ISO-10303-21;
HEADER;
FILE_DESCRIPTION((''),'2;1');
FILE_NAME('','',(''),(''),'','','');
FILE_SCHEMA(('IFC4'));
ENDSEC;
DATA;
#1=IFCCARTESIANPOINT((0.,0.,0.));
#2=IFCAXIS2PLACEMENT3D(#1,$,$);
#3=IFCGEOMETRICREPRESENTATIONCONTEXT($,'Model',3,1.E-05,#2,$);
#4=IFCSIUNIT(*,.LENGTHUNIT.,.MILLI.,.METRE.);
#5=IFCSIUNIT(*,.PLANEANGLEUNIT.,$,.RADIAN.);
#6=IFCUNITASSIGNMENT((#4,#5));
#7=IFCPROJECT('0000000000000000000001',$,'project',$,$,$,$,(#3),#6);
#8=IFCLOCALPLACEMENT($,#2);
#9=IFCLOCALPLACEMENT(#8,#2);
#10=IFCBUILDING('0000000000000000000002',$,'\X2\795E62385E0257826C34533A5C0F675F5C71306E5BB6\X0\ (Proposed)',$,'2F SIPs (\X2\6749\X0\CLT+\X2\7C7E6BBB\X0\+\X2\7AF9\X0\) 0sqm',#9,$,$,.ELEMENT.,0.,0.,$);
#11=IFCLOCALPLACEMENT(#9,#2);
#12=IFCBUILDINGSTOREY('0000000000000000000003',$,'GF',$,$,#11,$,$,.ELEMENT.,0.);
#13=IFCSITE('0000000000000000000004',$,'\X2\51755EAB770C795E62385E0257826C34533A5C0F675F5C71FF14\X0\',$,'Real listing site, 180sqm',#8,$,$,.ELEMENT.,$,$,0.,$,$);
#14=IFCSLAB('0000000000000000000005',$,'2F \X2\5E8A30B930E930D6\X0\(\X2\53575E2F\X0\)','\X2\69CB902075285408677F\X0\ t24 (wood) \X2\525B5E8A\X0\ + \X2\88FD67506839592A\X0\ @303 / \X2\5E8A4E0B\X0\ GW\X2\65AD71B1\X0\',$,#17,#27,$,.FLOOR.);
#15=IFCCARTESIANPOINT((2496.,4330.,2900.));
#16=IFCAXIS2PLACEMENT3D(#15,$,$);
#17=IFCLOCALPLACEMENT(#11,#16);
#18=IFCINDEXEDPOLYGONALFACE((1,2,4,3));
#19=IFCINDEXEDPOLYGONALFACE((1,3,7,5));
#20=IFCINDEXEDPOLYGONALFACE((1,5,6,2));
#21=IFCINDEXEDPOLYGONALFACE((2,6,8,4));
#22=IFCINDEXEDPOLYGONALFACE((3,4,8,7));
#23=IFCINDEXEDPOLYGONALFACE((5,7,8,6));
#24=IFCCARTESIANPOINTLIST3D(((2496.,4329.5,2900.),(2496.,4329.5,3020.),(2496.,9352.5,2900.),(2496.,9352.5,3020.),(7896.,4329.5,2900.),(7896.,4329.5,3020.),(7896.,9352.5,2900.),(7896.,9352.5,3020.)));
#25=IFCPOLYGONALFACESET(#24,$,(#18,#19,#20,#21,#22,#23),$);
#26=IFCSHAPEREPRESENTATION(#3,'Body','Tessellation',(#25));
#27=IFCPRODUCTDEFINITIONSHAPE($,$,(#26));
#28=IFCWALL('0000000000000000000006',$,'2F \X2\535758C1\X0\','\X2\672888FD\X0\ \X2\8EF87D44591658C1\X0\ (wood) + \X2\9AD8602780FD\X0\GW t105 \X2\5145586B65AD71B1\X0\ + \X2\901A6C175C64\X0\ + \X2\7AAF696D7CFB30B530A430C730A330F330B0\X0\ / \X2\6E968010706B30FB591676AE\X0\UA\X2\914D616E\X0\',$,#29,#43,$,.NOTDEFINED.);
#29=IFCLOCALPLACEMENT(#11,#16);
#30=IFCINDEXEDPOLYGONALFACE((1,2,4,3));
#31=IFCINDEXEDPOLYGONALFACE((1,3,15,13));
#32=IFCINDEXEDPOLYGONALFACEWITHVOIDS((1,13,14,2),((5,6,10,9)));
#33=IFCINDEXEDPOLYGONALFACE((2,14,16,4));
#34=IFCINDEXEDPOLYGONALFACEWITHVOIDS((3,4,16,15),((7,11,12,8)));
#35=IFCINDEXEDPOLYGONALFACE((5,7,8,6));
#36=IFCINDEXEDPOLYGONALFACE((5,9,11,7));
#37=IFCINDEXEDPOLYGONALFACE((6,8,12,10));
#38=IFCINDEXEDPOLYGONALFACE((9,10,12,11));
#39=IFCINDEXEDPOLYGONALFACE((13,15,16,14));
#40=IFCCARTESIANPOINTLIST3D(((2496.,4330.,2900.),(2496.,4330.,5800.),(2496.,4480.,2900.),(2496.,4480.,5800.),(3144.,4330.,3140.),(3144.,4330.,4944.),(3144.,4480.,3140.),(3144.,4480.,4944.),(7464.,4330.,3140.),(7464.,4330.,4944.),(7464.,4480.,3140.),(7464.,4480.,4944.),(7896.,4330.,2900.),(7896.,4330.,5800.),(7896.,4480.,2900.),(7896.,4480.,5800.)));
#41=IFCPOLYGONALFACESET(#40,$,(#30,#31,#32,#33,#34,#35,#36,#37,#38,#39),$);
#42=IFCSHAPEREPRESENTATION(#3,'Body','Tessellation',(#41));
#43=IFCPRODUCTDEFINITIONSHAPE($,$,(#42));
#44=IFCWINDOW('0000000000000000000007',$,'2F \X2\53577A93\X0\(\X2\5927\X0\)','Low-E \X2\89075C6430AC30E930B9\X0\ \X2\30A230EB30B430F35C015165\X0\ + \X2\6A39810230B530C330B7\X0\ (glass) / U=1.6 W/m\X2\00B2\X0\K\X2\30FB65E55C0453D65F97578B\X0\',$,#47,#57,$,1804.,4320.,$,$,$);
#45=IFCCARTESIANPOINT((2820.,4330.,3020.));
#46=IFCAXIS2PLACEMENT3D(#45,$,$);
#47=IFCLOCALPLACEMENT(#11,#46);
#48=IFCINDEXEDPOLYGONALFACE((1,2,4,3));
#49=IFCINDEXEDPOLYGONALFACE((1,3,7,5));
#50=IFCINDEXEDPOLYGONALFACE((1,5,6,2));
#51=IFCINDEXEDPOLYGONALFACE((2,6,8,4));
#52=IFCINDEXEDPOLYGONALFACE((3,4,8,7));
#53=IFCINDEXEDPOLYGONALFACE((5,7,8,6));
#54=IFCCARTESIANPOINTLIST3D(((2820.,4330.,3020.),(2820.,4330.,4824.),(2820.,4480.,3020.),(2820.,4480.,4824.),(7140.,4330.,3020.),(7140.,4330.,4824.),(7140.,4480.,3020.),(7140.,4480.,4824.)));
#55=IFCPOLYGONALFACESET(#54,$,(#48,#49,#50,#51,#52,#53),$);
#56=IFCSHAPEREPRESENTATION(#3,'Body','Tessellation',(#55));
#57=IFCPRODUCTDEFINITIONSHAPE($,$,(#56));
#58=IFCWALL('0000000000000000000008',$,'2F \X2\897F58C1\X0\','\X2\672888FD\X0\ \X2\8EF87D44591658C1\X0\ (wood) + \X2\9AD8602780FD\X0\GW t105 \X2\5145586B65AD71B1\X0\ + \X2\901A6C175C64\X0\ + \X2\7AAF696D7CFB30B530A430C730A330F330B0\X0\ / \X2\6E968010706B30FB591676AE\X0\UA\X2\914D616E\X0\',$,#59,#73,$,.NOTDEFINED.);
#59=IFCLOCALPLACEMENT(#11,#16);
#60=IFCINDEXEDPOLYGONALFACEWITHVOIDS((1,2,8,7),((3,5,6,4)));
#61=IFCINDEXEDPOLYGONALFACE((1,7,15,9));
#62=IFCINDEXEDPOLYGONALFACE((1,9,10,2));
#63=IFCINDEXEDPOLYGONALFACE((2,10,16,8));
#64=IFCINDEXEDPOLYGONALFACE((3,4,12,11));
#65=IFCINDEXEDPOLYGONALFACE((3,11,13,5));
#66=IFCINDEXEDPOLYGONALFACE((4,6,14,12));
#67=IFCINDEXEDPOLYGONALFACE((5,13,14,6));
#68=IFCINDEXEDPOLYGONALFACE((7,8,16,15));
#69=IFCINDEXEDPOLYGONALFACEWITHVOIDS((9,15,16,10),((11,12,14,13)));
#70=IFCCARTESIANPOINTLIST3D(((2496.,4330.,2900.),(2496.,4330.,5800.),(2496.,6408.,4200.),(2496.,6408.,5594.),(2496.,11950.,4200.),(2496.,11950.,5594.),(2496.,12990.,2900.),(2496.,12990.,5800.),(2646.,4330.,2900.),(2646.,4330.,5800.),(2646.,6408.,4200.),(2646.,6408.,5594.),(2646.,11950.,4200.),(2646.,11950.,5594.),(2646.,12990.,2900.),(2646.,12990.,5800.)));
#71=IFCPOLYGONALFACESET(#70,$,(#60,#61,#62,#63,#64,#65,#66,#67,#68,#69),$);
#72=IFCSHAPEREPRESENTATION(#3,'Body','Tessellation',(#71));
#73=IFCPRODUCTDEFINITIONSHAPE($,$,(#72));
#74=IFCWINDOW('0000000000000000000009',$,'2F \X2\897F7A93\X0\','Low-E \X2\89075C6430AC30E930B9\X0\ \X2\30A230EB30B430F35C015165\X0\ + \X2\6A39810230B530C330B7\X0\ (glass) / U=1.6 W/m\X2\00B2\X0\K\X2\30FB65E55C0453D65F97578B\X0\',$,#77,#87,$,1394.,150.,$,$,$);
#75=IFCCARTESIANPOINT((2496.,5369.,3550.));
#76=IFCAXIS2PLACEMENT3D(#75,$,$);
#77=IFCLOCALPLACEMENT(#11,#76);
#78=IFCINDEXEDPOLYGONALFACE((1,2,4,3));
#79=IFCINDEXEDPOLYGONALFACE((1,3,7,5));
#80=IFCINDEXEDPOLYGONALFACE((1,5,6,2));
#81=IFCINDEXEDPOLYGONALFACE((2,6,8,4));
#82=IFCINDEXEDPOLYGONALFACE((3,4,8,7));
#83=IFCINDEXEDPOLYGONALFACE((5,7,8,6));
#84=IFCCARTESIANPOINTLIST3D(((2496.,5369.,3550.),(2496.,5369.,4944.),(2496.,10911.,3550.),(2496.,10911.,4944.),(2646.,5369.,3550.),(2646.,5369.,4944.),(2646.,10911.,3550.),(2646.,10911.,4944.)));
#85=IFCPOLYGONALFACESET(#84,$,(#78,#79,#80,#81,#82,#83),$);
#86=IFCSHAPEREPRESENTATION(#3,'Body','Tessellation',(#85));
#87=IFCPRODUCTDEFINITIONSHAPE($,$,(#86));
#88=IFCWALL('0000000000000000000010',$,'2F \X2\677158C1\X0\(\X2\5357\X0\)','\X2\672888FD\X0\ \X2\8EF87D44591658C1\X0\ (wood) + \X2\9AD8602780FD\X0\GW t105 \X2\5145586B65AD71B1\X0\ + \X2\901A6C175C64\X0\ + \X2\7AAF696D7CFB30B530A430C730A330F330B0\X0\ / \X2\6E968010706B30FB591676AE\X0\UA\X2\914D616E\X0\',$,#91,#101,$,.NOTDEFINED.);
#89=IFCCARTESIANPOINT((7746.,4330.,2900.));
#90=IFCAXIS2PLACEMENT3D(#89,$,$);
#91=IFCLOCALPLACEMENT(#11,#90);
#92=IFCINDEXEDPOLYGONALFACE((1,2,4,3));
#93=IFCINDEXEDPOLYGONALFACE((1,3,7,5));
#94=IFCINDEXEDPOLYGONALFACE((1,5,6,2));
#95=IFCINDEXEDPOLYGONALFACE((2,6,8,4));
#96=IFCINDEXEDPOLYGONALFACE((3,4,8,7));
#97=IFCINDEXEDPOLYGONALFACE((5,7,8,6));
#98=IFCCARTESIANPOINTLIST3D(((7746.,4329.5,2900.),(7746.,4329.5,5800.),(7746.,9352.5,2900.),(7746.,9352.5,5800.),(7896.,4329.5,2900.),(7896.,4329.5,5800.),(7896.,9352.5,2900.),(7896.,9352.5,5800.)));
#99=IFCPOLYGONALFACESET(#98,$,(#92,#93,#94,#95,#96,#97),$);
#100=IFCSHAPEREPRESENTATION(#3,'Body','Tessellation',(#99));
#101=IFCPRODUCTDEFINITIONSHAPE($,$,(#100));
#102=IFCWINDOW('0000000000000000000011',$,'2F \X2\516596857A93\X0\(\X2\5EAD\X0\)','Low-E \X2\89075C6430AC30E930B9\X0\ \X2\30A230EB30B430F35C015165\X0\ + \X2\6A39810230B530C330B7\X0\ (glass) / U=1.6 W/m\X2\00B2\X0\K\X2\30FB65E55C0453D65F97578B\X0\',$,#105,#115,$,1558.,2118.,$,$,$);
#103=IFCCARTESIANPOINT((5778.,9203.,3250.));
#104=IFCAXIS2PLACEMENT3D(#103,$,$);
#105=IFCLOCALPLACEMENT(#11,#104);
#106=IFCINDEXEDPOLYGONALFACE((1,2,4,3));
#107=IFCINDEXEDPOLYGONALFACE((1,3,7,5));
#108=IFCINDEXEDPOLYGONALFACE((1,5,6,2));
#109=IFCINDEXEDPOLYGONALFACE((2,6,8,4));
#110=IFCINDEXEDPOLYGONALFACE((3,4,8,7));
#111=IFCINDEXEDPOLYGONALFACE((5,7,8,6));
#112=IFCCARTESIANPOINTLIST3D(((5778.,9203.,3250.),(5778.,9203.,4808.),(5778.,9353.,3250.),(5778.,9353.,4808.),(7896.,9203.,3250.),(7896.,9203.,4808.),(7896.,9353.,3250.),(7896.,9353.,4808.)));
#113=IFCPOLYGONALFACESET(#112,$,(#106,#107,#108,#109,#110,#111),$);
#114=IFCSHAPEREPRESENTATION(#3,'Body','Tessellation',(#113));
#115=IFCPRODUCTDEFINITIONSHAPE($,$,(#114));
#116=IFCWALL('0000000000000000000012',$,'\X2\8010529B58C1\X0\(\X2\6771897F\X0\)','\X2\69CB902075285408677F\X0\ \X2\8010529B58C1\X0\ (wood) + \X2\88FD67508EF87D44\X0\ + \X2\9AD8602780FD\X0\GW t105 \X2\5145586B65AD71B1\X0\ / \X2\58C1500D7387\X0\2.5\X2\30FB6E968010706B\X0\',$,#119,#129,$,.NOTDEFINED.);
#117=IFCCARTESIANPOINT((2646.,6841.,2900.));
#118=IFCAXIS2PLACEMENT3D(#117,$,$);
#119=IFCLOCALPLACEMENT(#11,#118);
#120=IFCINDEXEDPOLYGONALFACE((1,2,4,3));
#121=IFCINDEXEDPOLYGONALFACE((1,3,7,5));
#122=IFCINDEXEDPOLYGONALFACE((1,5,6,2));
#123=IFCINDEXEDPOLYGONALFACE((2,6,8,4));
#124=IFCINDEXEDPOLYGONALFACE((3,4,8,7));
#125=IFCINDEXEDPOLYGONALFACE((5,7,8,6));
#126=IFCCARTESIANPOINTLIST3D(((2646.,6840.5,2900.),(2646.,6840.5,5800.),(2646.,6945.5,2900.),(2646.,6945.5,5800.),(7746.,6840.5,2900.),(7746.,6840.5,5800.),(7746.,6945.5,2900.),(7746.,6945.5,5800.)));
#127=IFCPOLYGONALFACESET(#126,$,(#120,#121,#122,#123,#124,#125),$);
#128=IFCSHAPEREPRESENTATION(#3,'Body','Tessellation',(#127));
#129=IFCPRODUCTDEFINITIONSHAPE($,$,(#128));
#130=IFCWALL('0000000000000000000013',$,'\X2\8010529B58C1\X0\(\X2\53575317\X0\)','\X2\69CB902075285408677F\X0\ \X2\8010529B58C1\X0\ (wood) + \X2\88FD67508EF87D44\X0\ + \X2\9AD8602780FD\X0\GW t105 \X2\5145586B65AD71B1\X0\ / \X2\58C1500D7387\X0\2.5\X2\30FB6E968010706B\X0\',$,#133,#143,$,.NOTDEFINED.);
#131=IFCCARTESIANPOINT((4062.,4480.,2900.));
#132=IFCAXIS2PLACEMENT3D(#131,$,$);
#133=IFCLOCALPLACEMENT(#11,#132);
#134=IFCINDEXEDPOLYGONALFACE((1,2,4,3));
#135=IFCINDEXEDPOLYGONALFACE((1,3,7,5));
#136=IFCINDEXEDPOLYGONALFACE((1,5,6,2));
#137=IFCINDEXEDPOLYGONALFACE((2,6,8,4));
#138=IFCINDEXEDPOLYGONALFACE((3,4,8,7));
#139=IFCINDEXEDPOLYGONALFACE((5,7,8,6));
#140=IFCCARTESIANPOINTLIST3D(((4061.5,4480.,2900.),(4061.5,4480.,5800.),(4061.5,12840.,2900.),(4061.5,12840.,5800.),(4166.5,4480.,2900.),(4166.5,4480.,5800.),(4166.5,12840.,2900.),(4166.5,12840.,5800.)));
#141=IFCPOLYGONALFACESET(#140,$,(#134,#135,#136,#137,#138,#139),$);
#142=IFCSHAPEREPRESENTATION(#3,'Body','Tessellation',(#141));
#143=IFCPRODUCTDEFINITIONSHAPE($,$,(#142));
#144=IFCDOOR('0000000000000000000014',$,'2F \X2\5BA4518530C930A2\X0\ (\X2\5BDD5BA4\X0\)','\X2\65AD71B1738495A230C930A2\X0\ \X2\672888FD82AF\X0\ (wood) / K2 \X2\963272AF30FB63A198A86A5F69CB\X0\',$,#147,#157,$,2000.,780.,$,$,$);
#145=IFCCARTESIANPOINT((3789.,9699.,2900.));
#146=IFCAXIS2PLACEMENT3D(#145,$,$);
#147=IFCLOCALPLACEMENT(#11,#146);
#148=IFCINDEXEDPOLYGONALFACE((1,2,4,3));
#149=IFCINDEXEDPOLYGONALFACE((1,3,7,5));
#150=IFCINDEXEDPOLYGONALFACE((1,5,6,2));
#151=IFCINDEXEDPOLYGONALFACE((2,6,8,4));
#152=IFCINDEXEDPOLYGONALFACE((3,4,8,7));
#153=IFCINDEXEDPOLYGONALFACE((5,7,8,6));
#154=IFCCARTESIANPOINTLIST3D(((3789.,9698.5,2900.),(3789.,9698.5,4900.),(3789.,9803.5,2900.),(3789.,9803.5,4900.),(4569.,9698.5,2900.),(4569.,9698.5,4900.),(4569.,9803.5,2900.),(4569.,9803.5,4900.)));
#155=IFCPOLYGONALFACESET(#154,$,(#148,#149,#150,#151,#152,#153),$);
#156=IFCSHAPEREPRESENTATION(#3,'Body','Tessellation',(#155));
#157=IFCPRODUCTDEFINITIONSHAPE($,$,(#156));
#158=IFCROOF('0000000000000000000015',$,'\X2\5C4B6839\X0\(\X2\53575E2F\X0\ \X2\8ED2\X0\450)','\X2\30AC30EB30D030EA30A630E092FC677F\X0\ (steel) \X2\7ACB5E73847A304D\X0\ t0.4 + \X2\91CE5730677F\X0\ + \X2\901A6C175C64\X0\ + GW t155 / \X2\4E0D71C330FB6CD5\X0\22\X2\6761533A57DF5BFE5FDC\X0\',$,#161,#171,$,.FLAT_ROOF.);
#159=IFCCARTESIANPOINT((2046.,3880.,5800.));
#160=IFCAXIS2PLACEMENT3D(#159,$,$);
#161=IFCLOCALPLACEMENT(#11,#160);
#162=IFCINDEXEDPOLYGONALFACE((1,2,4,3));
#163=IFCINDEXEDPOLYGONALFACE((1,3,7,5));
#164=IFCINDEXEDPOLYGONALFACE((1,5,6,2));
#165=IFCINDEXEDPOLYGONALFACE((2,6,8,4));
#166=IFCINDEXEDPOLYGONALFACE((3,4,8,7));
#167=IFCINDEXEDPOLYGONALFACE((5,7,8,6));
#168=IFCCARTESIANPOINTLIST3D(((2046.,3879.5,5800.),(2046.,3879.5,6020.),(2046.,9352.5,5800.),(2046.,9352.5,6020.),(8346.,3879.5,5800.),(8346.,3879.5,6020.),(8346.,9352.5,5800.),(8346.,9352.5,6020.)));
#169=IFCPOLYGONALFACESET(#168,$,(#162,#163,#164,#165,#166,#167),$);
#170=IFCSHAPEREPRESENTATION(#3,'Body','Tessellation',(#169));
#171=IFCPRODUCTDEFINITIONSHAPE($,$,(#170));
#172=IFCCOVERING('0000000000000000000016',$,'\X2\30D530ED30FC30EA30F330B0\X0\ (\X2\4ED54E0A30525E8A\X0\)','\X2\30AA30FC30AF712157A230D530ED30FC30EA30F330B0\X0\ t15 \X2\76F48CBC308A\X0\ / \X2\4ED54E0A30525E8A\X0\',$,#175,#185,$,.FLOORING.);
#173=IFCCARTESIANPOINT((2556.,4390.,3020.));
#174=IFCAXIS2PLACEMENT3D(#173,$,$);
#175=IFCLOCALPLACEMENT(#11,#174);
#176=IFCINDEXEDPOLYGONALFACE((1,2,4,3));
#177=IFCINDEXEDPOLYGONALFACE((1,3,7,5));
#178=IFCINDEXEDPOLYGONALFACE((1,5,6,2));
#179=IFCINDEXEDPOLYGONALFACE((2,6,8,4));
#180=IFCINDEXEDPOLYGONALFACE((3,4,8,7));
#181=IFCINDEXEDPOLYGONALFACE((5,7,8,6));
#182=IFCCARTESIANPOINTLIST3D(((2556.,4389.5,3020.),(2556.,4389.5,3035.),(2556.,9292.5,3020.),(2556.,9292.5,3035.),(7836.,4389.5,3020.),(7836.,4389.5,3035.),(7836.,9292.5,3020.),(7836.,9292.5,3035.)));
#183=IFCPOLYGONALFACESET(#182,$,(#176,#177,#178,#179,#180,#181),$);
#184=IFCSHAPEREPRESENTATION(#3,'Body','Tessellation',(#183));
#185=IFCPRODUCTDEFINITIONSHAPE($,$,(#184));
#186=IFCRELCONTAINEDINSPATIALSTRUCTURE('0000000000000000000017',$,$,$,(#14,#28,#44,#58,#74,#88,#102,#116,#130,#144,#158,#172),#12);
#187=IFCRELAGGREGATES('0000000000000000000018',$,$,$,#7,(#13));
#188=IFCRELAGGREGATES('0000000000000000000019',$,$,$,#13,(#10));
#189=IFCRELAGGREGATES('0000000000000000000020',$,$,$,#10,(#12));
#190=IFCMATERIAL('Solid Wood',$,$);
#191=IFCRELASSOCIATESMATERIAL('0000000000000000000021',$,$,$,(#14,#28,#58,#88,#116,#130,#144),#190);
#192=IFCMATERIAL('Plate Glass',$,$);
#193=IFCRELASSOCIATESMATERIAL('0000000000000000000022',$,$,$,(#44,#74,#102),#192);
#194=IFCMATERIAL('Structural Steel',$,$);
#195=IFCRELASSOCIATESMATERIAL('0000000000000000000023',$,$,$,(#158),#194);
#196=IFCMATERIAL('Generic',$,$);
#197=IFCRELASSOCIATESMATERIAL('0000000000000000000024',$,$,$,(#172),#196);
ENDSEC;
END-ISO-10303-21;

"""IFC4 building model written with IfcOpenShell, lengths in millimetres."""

from ifc_helpers import new_model, si_unit, frame, frame_2d, origin, place, context, project, spatial, rectangle, extrude, material, element, fill, save


model = new_model("IFC4")

# Units and contexts
model_context = context("Model", 3, precision=1e-05, world=origin())
ifc_project = project(units=[si_unit("LENGTHUNIT", "METRE", prefix="MILLI"), si_unit("PLANEANGLEUNIT", "RADIAN")], contexts=[model_context])

# Site, building, storey
site_placement = place(None, origin())
site = spatial("IfcSite", under=ifc_project, at=site_placement, Name="兵庫県神戸市垂水区小束山４", ObjectType="Real listing site, 180sqm", CompositionType="ELEMENT", RefElevation=0.0)
building_placement = place(site_placement, origin())
building = spatial("IfcBuilding", under=site, at=building_placement, Name="神戸市垂水区小束山の家 (Proposed)", ObjectType="2F SIPs (杉CLT+籾殻+竹) 0sqm", CompositionType="ELEMENT", ElevationOfRefHeight=0.0, ElevationOfTerrain=0.0)
storey_placement = place(building_placement, origin())
storey = spatial("IfcBuildingStorey", under=building, at=storey_placement, Name="GF", CompositionType="ELEMENT", Elevation=0.0)

# Slab
ifc_material_1 = material(Name="Solid Wood")
slab_placement = place(storey_placement, frame((2496.0, 4330.0, 2900.0)))
element("IfcSlab", 1, at=slab_placement, inside=storey, material=ifc_material_1, Name="2F 床スラブ(南帯)", Description="構造用合板 t24 (wood) 剛床 + 製材根太 @303 / 床下 GW断熱", PredefinedType="FLOOR", context=model_context, shape_type="SweptSolid", body=[
    extrude(rectangle(XDim=5400.0, YDim=5023.0, at=frame_2d((2700.0, 2511.0))), frame((2496.0, 4330.0, 2900.0)), (0.0, 0.0, 1.0), 120.0),
])

# Walls, openings, windows
wall_1_placement = place(storey_placement, frame((2496.0, 4330.0, 2900.0)))
wall_1 = element("IfcWall", 2, at=wall_1_placement, inside=storey, material=ifc_material_1, Name="2F 南壁", Description="木製 軸組外壁 (wood) + 高性能GW t105 充填断熱 + 通気層 + 窯業系サイディング / 準耐火・外皮UA配慮", PredefinedType="NOTDEFINED", context=model_context, shape_type="SweptSolid", body=[
    extrude(rectangle(XDim=5400.0, YDim=150.0, at=frame_2d((2700.0, 75.0))), frame((2496.0, 4330.0, 2900.0)), (0.0, 0.0, 1.0), 2900.0),
])
opening_1_placement = place(storey_placement, frame((2820.0, 4330.0, 3020.0)))
opening_1 = element("IfcOpeningElement", 3, at=opening_1_placement, cuts=wall_1, PredefinedType="NOTDEFINED", context=model_context, shape_type="SweptSolid", body=[
    extrude(rectangle(XDim=4320.0, YDim=150.0, at=frame_2d((2160.0, 75.0))), frame((2820.0, 4330.0, 3020.0)), (0.0, 0.0, 1.0), 1804.0),
])
ifc_material_2 = material(Name="Plate Glass")
window_1_placement = place(storey_placement, frame((2820.0, 4330.0, 3020.0)))
window_1 = element("IfcWindow", 4, at=window_1_placement, inside=storey, material=ifc_material_2, Name="2F 南窓(大)", Description="Low-E 複層ガラス アルゴン封入 + 樹脂サッシ (glass) / U=1.6 W/m²K・日射取得型", OverallHeight=1804.0, OverallWidth=4320.0, context=model_context, shape_type="SweptSolid", body=[
    extrude(rectangle(XDim=4320.0, YDim=150.0, at=frame_2d((2160.0, 75.0))), frame((2820.0, 4330.0, 3020.0)), (0.0, 0.0, 1.0), 1804.0),
])
fill(opening_1, window_1)
wall_2_placement = place(storey_placement, frame((2496.0, 4330.0, 2900.0)))
wall_2 = element("IfcWall", 5, at=wall_2_placement, inside=storey, material=ifc_material_1, Name="2F 西壁", Description="木製 軸組外壁 (wood) + 高性能GW t105 充填断熱 + 通気層 + 窯業系サイディング / 準耐火・外皮UA配慮", PredefinedType="NOTDEFINED", context=model_context, shape_type="SweptSolid", body=[
    extrude(rectangle(XDim=150.0, YDim=8660.0, at=frame_2d((75.0, 4330.0))), frame((2496.0, 4330.0, 2900.0)), (0.0, 0.0, 1.0), 2900.0),
])
opening_2_placement = place(storey_placement, frame((2496.0, 5369.0, 3550.0)))
opening_2 = element("IfcOpeningElement", 6, at=opening_2_placement, cuts=wall_2, PredefinedType="NOTDEFINED", context=model_context, shape_type="SweptSolid", body=[
    extrude(rectangle(XDim=150.0, YDim=5542.0, at=frame_2d((75.0, 2771.0))), frame((2496.0, 5369.0, 3550.0)), (0.0, 0.0, 1.0), 1394.0),
])
window_2_placement = place(storey_placement, frame((2496.0, 5369.0, 3550.0)))
window_2 = element("IfcWindow", 7, at=window_2_placement, inside=storey, material=ifc_material_2, Name="2F 西窓", Description="Low-E 複層ガラス アルゴン封入 + 樹脂サッシ (glass) / U=1.6 W/m²K・日射取得型", OverallHeight=1394.0, OverallWidth=150.0, context=model_context, shape_type="SweptSolid", body=[
    extrude(rectangle(XDim=150.0, YDim=5542.0, at=frame_2d((75.0, 2771.0))), frame((2496.0, 5369.0, 3550.0)), (0.0, 0.0, 1.0), 1394.0),
])
fill(opening_2, window_2)
wall_3_placement = place(storey_placement, frame((7746.0, 4330.0, 2900.0)))
wall_3 = element("IfcWall", 8, at=wall_3_placement, inside=storey, material=ifc_material_1, Name="2F 東壁(南)", Description="木製 軸組外壁 (wood) + 高性能GW t105 充填断熱 + 通気層 + 窯業系サイディング / 準耐火・外皮UA配慮", PredefinedType="NOTDEFINED", context=model_context, shape_type="SweptSolid", body=[
    extrude(rectangle(XDim=150.0, YDim=5023.0, at=frame_2d((75.0, 2511.0))), frame((7746.0, 4330.0, 2900.0)), (0.0, 0.0, 1.0), 2900.0),
])
opening_3_placement = place(storey_placement, frame((5778.0, 9203.0, 3250.0)))
opening_3 = element("IfcOpeningElement", 9, at=opening_3_placement, cuts=wall_3, PredefinedType="NOTDEFINED", context=model_context, shape_type="SweptSolid", body=[
    extrude(rectangle(XDim=2118.0, YDim=150.0, at=frame_2d((1059.0, 75.0))), frame((5778.0, 9203.0, 3250.0)), (0.0, 0.0, 1.0), 1558.0),
])
window_3_placement = place(storey_placement, frame((5778.0, 9203.0, 3250.0)))
window_3 = element("IfcWindow", 10, at=window_3_placement, inside=storey, material=ifc_material_2, Name="2F 入隅窓(庭)", Description="Low-E 複層ガラス アルゴン封入 + 樹脂サッシ (glass) / U=1.6 W/m²K・日射取得型", OverallHeight=1558.0, OverallWidth=2118.0, context=model_context, shape_type="SweptSolid", body=[
    extrude(rectangle(XDim=2118.0, YDim=150.0, at=frame_2d((1059.0, 75.0))), frame((5778.0, 9203.0, 3250.0)), (0.0, 0.0, 1.0), 1558.0),
])
fill(opening_3, window_3)

# Wall
wall_4_placement = place(storey_placement, frame((2646.0, 6841.0, 2900.0)))
element("IfcWall", 11, at=wall_4_placement, inside=storey, material=ifc_material_1, Name="耐力壁(東西)", Description="構造用合板 耐力壁 (wood) + 製材軸組 + 高性能GW t105 充填断熱 / 壁倍率2.5・準耐火", PredefinedType="NOTDEFINED", context=model_context, shape_type="SweptSolid", body=[
    extrude(rectangle(XDim=5100.0, YDim=105.0, at=frame_2d((2550.0, 52.0))), frame((2646.0, 6841.0, 2900.0)), (0.0, 0.0, 1.0), 2900.0),
])

# Wall, opening, door
wall_5_placement = place(storey_placement, frame((4062.0, 4480.0, 2900.0)))
wall_5 = element("IfcWall", 12, at=wall_5_placement, inside=storey, material=ifc_material_1, Name="耐力壁(南北)", Description="構造用合板 耐力壁 (wood) + 製材軸組 + 高性能GW t105 充填断熱 / 壁倍率2.5・準耐火", PredefinedType="NOTDEFINED", context=model_context, shape_type="SweptSolid", body=[
    extrude(rectangle(XDim=105.0, YDim=8360.0, at=frame_2d((52.0, 4180.0))), frame((4062.0, 4480.0, 2900.0)), (0.0, 0.0, 1.0), 2900.0),
])
opening_4_placement = place(storey_placement, frame((3789.0, 9699.0, 2900.0)))
opening_4 = element("IfcOpeningElement", 13, at=opening_4_placement, cuts=wall_5, PredefinedType="NOTDEFINED", context=model_context, shape_type="SweptSolid", body=[
    extrude(rectangle(XDim=780.0, YDim=105.0, at=frame_2d((390.0, 52.0))), frame((3789.0, 9699.0, 2900.0)), (0.0, 0.0, 1.0), 2000.0),
])
door_placement = place(storey_placement, frame((3789.0, 9699.0, 2900.0)))
door = element("IfcDoor", 14, at=door_placement, inside=storey, material=ifc_material_1, Name="2F 室内ドア (寝室)", Description="断熱玄関ドア 木製芯 (wood) / K2 防犯・採風機構", OverallHeight=2000.0, OverallWidth=780.0, context=model_context, shape_type="SweptSolid", body=[
    extrude(rectangle(XDim=780.0, YDim=105.0, at=frame_2d((390.0, 52.0))), frame((3789.0, 9699.0, 2900.0)), (0.0, 0.0, 1.0), 2000.0),
])
fill(opening_4, door)

# Roof
ifc_material_3 = material(Name="Structural Steel")
for number, where, name in (
    (15, (2046.0, 3880.0, 5800.0), "屋根(南帯 軒450)"),
):
    element("IfcRoof", number, at=place(storey_placement, frame(where)), inside=storey, material=ifc_material_3, Name=name, Description="ガルバリウム鋼板 (steel) 立平葺き t0.4 + 野地板 + 通気層 + GW t155 / 不燃・法22条区域対応", PredefinedType="FLAT_ROOF", context=model_context, shape_type="SweptSolid", body=[
        extrude(rectangle(XDim=6300.0, YDim=5473.0, at=frame_2d((3150.0, 2736.0))), frame((2046.0, 3880.0, 5800.0)), (0.0, 0.0, 1.0), 220.0),
    ])

# Covering
ifc_material_4 = material(Name="Generic")
covering_placement = place(storey_placement, frame((2556.0, 4390.0, 3020.0)))
element("IfcCovering", 16, at=covering_placement, inside=storey, material=ifc_material_4, Name="フローリング (仕上げ床)", Description="オーク無垢フローリング t15 直貼り / 仕上げ床", PredefinedType="FLOORING", context=model_context, shape_type="SweptSolid", body=[
    extrude(rectangle(XDim=5280.0, YDim=4903.0, at=frame_2d((2640.0, 2451.0))), frame((2556.0, 4390.0, 3020.0)), (0.0, 0.0, 1.0), 15.0),
])

save(model, "model.ifc")
